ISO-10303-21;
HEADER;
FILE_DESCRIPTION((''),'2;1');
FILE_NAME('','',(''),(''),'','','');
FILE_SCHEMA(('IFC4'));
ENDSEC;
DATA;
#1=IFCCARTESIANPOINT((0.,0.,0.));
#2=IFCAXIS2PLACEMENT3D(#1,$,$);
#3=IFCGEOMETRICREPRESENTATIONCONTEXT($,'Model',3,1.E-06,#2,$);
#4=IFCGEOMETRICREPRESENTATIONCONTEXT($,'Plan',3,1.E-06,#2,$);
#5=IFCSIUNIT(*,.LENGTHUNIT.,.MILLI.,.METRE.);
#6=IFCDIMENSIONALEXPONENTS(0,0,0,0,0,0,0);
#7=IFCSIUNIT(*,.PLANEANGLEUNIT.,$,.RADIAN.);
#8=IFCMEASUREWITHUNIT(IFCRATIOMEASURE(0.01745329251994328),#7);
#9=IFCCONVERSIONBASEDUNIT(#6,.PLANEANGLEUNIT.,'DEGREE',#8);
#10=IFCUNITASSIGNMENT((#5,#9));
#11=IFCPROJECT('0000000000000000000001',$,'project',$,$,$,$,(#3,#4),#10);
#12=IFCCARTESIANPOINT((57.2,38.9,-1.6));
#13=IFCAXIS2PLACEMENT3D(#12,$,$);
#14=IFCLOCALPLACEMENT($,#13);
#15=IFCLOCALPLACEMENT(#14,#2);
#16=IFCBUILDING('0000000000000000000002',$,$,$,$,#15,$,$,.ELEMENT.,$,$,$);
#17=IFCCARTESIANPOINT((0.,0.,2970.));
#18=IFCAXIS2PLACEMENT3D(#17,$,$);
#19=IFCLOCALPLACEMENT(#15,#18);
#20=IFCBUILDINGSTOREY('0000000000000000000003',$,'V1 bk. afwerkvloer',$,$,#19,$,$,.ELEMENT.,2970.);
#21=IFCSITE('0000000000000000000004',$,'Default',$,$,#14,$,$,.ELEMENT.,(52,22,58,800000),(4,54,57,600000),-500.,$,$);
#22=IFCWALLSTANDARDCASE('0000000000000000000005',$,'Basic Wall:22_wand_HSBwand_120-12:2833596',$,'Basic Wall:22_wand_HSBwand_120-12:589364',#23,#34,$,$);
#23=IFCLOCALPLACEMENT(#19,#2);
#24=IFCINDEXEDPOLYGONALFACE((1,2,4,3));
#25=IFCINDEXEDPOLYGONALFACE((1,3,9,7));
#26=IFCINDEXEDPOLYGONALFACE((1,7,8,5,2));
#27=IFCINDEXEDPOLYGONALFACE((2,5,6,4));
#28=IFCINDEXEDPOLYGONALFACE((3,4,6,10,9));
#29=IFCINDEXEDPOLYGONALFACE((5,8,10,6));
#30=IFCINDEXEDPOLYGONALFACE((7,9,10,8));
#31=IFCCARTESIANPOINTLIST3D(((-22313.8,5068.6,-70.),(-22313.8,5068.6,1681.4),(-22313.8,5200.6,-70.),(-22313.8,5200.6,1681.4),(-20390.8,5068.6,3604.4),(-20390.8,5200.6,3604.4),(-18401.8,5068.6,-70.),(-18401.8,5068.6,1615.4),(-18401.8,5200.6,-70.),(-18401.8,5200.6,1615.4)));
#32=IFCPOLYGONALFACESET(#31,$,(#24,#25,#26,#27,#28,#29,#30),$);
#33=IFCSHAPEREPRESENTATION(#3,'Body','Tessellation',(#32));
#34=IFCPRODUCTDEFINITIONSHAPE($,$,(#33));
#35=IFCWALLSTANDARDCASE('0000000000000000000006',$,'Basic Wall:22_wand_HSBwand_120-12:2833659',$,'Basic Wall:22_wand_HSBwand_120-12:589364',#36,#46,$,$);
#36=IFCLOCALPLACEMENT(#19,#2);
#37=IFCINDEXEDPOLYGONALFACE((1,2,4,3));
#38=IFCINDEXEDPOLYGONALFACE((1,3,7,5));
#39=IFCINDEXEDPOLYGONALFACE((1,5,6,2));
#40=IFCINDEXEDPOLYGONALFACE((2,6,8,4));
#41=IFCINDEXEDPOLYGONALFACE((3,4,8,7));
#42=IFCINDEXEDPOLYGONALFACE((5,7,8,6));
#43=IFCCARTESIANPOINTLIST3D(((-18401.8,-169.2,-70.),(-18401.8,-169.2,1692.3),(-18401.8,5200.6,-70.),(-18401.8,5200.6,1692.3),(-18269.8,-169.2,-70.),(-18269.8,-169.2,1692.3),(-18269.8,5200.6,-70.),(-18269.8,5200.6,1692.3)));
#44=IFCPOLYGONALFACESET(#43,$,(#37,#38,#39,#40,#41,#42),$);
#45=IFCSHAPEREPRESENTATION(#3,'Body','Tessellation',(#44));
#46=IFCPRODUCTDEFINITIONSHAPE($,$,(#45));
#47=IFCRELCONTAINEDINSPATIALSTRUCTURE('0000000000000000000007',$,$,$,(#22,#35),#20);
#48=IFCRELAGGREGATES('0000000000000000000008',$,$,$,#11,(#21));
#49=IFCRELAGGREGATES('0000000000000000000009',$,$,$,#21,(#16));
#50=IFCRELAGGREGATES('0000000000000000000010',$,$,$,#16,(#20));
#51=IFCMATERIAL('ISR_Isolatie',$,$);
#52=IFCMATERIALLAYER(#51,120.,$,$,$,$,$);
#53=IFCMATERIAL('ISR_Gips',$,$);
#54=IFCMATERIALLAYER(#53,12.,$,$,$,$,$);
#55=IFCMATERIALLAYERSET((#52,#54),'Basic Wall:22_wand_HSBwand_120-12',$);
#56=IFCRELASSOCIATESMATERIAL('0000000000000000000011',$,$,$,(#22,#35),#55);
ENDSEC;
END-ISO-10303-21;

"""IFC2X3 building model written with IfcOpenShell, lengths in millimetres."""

from ifc_helpers import new_model, entity, si_unit, converted_unit, frame, frame_2d, origin, place, context, project, spatial, rectangle, extrude, clip, halfspace, material, layer, layer_set, layer_usage, element, save


model = new_model("IFC2X3")

# Units and contexts
model_context = context("Model", 3, precision=1e-06, world=origin())
plan_context = context("Plan", 3, precision=1e-06, world=origin())
ifc_project = project(units=[si_unit("LENGTHUNIT", "METRE", prefix="MILLI"), converted_unit("PLANEANGLEUNIT", "DEGREE", entity("IfcRatioMeasure", 0.01745329251994328), si_unit("PLANEANGLEUNIT", "RADIAN"), dimensions=[0, 0, 0, 0, 0, 0, 0])], contexts=[model_context, plan_context])

# Site, building, storey
site_placement = place(None, frame((57.2, 38.9, -1.6)))
site = spatial("IfcSite", under=ifc_project, at=site_placement, Name="Default", CompositionType="ELEMENT", RefLatitude=(52, 22, 58, 800000), RefLongitude=(4, 54, 57, 600000), RefElevation=-500.0)
building_placement = place(site_placement, origin())
building = spatial("IfcBuilding", under=site, at=building_placement, CompositionType="ELEMENT")
storey_placement = place(building_placement, frame((0.0, 0.0, 2970.0)))
storey = spatial("IfcBuildingStorey", under=building, at=storey_placement, Name="V1 bk. afwerkvloer", CompositionType="ELEMENT", Elevation=2970.0)

# Walls
ifc_material_1 = material(Name="ISR_Isolatie")
ifc_layer_1 = layer(ifc_material_1, 120.0)
ifc_material_2 = material(Name="ISR_Gips")
ifc_layer_2 = layer(ifc_material_2, 12.0)
ifc_layer_set_1 = layer_set([ifc_layer_1, ifc_layer_2], Name="Basic Wall:22_wand_HSBwand_120-12")
ifc_layer_usage_1 = layer_usage(ifc_layer_set_1, "AXIS2", "NEGATIVE", 66.0)
wall_1_placement = place(storey_placement, frame((-22313.8, 5134.6, -70.0)))
element("IfcWallStandardCase", 1, at=wall_1_placement, inside=storey, material=ifc_layer_usage_1, Name="Basic Wall:22_wand_HSBwand_120-12:2833596", ObjectType="Basic Wall:22_wand_HSBwand_120-12:589364", context=model_context, shape_type="Clipping", body=[
    clip(clip(extrude(rectangle(XDim=3912.0, YDim=132.0, at=frame_2d((1956.0, 0.0), x_axis=(-1.0, 0.0))), origin(), (0.0, 0.0, 1.0), 3674.4), halfspace(frame((0.0, -66.0, 1751.4), z_axis=(-0.707107, 0.0, 0.707107), x_axis=(0.0, 1.0, 0.0)), False)), halfspace(frame((1923.0, -66.0, 3674.4), z_axis=(0.707107, 0.0, 0.707107), x_axis=(0.0, 1.0, 0.0)), False)),
])
ifc_layer_usage_2 = layer_usage(ifc_layer_set_1, "AXIS2", "NEGATIVE", 66.0)
wall_2_placement = place(storey_placement, frame((-18335.8, 5200.6, -70.0), z_axis=(0.0, 0.0, 1.0), x_axis=(0.0, -1.0, 0.0)))
element("IfcWallStandardCase", 2, at=wall_2_placement, inside=storey, material=ifc_layer_usage_2, Name="Basic Wall:22_wand_HSBwand_120-12:2833659", ObjectType="Basic Wall:22_wand_HSBwand_120-12:589364", context=model_context, shape_type="SweptSolid", body=[
    extrude(rectangle(XDim=5369.9, YDim=132.0, at=frame_2d((2684.9, 0.0), x_axis=(-1.0, 0.0))), origin(), (0.0, 0.0, 1.0), 1762.3),
])

save(model, "model.ifc")
